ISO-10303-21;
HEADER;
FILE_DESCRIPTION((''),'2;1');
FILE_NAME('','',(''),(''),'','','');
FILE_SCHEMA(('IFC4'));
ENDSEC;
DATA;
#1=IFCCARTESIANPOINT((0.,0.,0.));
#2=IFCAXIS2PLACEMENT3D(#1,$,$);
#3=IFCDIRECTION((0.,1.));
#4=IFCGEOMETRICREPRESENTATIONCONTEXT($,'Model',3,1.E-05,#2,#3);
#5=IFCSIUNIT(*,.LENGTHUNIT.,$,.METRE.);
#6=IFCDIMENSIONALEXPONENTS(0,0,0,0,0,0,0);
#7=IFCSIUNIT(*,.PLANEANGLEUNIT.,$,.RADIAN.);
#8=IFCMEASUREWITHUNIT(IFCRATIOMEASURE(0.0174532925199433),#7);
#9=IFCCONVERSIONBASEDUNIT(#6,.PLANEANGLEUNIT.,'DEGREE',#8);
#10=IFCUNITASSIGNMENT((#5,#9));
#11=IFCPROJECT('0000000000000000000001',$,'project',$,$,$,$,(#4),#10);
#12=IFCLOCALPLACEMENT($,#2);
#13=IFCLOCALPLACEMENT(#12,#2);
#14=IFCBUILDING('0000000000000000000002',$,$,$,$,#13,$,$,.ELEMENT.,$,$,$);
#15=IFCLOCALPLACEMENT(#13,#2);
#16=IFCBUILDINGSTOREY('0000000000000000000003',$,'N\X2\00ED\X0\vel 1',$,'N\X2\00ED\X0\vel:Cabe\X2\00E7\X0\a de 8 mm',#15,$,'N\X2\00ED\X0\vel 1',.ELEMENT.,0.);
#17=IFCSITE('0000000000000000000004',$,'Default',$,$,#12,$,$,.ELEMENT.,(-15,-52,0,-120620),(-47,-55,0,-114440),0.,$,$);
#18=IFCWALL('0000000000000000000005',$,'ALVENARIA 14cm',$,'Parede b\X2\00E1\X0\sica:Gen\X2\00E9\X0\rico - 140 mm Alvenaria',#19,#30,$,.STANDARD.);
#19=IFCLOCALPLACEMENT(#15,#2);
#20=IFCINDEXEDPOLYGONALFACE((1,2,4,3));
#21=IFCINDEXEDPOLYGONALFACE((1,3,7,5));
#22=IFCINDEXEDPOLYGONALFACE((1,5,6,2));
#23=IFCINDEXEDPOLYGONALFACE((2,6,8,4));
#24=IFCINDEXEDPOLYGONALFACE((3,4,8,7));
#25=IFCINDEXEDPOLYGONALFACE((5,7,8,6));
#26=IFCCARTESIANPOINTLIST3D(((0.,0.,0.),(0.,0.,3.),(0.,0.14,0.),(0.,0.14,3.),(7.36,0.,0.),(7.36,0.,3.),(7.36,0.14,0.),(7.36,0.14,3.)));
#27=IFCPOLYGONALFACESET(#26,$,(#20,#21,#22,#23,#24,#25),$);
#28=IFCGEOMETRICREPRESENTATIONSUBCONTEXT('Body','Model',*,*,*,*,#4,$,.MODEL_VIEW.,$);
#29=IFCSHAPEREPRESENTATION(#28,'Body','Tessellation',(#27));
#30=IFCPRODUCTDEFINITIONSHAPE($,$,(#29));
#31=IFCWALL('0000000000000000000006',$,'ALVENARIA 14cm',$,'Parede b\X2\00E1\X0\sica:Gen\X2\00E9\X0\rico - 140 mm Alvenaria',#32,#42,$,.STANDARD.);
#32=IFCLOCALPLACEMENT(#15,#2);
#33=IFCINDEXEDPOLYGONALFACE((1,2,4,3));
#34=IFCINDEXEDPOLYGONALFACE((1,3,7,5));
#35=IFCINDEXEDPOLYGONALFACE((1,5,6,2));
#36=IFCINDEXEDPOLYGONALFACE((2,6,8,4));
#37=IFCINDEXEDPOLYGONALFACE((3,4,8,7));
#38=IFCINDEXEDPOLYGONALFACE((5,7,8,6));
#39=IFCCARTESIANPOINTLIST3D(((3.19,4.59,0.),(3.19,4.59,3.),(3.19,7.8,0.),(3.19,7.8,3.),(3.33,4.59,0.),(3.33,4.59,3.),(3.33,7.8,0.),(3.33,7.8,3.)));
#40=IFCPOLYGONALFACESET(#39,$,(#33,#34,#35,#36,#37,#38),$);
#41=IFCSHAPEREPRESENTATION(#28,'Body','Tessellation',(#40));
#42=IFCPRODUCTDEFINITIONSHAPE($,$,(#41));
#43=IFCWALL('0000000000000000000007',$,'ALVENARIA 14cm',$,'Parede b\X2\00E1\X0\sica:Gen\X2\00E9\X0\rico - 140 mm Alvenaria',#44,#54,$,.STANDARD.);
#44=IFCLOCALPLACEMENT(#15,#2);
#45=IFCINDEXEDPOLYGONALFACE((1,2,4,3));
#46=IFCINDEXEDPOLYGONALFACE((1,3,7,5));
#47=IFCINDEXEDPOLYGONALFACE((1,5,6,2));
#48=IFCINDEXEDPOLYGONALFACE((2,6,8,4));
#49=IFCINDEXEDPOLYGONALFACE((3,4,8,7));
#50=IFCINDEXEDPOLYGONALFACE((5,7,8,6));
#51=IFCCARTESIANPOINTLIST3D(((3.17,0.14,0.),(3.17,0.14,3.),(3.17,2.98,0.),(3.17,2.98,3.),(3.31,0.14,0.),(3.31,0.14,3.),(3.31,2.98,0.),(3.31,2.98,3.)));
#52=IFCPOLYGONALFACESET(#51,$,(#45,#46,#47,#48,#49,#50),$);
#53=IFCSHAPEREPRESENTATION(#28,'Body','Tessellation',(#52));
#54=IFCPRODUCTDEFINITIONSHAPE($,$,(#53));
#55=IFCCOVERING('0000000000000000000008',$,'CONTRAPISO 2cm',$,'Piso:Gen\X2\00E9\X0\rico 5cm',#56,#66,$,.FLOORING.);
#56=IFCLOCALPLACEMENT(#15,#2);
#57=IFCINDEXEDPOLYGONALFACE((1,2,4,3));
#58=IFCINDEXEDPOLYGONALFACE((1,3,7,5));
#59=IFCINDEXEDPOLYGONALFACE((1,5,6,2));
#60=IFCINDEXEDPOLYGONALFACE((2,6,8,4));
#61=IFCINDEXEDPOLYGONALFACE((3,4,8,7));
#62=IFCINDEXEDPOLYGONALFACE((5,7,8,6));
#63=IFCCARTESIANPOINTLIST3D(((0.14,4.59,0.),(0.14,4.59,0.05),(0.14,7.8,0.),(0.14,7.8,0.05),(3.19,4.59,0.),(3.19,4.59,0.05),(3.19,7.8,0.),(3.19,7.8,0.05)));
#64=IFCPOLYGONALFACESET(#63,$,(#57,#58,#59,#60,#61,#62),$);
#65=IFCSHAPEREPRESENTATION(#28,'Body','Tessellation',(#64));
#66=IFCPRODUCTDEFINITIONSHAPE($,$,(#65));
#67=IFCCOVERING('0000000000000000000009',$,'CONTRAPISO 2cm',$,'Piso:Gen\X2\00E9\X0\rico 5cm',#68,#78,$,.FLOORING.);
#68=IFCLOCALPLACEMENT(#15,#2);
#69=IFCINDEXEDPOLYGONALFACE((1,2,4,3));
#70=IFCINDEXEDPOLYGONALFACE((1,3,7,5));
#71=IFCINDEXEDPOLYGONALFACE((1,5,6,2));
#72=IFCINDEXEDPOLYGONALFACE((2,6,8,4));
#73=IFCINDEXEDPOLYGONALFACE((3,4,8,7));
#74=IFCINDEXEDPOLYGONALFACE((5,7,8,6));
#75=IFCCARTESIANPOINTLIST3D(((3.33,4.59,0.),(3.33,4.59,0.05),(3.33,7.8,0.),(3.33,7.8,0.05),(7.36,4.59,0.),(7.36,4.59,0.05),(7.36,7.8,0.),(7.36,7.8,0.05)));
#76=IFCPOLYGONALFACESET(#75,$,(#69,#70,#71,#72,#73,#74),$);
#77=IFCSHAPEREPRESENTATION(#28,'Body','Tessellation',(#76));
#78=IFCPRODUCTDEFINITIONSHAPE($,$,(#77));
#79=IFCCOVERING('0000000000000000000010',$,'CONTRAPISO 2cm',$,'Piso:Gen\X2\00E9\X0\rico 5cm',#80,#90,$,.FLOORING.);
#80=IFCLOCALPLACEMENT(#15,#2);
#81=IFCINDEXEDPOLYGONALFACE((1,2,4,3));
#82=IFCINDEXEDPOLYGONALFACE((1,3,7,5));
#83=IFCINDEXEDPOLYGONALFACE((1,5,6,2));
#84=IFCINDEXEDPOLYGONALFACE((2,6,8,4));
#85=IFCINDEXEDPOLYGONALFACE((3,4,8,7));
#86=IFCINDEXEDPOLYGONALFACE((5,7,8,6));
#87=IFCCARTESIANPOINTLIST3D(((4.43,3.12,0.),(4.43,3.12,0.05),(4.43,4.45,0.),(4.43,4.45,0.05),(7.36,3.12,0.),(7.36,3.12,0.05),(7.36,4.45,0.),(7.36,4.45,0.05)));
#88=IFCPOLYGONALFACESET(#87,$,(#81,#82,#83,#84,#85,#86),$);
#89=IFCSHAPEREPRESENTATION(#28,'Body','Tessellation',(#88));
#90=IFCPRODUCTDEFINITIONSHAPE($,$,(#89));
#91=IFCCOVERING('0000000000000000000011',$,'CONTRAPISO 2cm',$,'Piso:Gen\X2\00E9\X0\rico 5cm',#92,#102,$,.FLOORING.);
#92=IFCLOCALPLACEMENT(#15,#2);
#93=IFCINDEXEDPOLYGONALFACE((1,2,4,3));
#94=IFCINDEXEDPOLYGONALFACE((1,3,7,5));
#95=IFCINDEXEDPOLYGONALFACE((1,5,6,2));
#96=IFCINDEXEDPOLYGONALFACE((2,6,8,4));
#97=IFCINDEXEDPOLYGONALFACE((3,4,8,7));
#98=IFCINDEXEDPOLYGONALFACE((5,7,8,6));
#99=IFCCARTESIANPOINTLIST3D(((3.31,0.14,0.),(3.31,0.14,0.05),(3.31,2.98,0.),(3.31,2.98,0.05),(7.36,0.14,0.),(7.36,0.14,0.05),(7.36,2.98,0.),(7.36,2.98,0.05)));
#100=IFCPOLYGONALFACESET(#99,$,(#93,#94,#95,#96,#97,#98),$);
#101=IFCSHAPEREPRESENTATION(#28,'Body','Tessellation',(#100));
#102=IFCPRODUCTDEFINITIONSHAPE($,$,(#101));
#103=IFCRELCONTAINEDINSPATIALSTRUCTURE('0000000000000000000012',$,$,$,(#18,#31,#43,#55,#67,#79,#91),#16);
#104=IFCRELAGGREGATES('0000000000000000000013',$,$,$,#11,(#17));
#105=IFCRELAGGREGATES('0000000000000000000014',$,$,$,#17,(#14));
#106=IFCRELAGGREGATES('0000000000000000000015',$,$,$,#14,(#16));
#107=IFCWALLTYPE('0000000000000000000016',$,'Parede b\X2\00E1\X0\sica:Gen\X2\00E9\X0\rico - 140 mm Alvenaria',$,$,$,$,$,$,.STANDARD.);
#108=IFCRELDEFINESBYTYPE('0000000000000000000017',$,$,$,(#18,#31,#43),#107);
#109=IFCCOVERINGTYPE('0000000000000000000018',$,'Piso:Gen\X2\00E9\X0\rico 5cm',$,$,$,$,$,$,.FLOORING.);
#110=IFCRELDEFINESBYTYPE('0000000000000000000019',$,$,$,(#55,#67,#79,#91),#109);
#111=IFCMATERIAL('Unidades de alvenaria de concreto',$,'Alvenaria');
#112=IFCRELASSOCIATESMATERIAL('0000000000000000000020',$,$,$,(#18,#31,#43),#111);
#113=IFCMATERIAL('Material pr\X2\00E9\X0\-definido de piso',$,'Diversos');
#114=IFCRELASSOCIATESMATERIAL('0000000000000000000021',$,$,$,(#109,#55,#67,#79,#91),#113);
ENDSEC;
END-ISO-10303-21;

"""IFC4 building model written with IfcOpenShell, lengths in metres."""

from ifc_helpers import new_model, entity, si_unit, converted_unit, direction, frame, origin, place, context, subcontext, project, spatial, indexed_curve, outline, extrude, material, type_object, element, save


model = new_model("IFC4")

# Units and contexts
model_context = context("Model", 3, precision=1e-05, world=origin(), true_north=direction((0.0, 1.0)))
body_context = subcontext(model_context, "Body", "Model", "MODEL_VIEW")
ifc_project = project(units=[si_unit("LENGTHUNIT", "METRE"), converted_unit("PLANEANGLEUNIT", "DEGREE", entity("IfcRatioMeasure", 0.0174532925199433), si_unit("PLANEANGLEUNIT", "RADIAN"), dimensions=[0, 0, 0, 0, 0, 0, 0])], contexts=[model_context])

# Site, building, storey
site_placement = place(None, origin())
site = spatial("IfcSite", under=ifc_project, at=site_placement, Name="Default", CompositionType="ELEMENT", RefLatitude=(-15, -52, 0, -120620), RefLongitude=(-47, -55, 0, -114440), RefElevation=0.0)
building_placement = place(site_placement, origin())
building = spatial("IfcBuilding", under=site, at=building_placement, CompositionType="ELEMENT")
storey_placement = place(building_placement, origin())
storey = spatial("IfcBuildingStorey", under=building, at=storey_placement, Name="Nível 1", ObjectType="Nível:Cabeça de 8 mm", LongName="Nível 1", CompositionType="ELEMENT", Elevation=0.0)

# Walls
ifc_material_1 = material(Name="Unidades de alvenaria de concreto", Category="Alvenaria")
wall_type = type_object("IfcWallType", Name="Parede básica:Genérico - 140 mm Alvenaria", PredefinedType="STANDARD")
wall_1_placement = place(storey_placement, frame((7.36, 0.07, 0.0), z_axis=(0.0, 0.0, 1.0), x_axis=(-1.0, 0.0, 0.0)))
element("IfcWall", 1, at=wall_1_placement, inside=storey, type_object=wall_type, material=ifc_material_1, Name="ALVENARIA 14cm", ObjectType="Parede básica:Genérico - 140 mm Alvenaria", PredefinedType="STANDARD", context=body_context, shape_type="SweptSolid", body=[
    extrude(outline(indexed_curve([(7.36, 0.07), (0.0, 0.07), (0.0, -0.07), (7.36, -0.07), (7.36, 0.07)], self_intersect=False)), origin(), (0.0, 0.0, 1.0), 3.0),
])
wall_2_placement = place(storey_placement, frame((3.26, 4.59, 0.0), z_axis=(0.0, 0.0, 1.0), x_axis=(0.0, 1.0, 0.0)))
element("IfcWall", 2, at=wall_2_placement, inside=storey, type_object=wall_type, material=ifc_material_1, Name="ALVENARIA 14cm", ObjectType="Parede básica:Genérico - 140 mm Alvenaria", PredefinedType="STANDARD", context=body_context, shape_type="SweptSolid", body=[
    extrude(outline(indexed_curve([(3.21, 0.07), (0.0, 0.07), (0.0, -0.07), (3.21, -0.07), (3.21, 0.07)], self_intersect=False)), origin(), (0.0, 0.0, 1.0), 3.0),
])
wall_3_placement = place(storey_placement, frame((3.24, 2.98, 0.0), z_axis=(0.0, 0.0, 1.0), x_axis=(0.0, -1.0, 0.0)))
element("IfcWall", 3, at=wall_3_placement, inside=storey, type_object=wall_type, material=ifc_material_1, Name="ALVENARIA 14cm", ObjectType="Parede básica:Genérico - 140 mm Alvenaria", PredefinedType="STANDARD", context=body_context, shape_type="SweptSolid", body=[
    extrude(outline(indexed_curve([(2.84, 0.07), (0.0, 0.07), (0.0, -0.07), (2.84, -0.07), (2.84, 0.07)], self_intersect=False)), origin(), (0.0, 0.0, 1.0), 3.0),
])

# Coverings
ifc_material_2 = material(Name="Material pré-definido de piso", Category="Diversos")
covering_type = type_object("IfcCoveringType", Name="Piso:Genérico 5cm", PredefinedType="FLOORING", material=ifc_material_2)
covering_1_placement = place(storey_placement, origin())
element("IfcCovering", 4, at=covering_1_placement, inside=storey, type_object=covering_type, material=ifc_material_2, Name="CONTRAPISO 2cm", ObjectType="Piso:Genérico 5cm", PredefinedType="FLOORING", context=body_context, shape_type="SweptSolid", body=[
    extrude(outline(indexed_curve([(-1.605, -1.525), (1.605, -1.525), (1.605, 1.525), (-1.605, 1.525), (-1.605, -1.525)], self_intersect=False)), frame((1.665, 6.195, 0.05), z_axis=(0.0, 0.0, -1.0), x_axis=(0.0, 1.0, 0.0)), (0.0, 0.0, 1.0), 0.05),
])
covering_2_placement = place(storey_placement, origin())
element("IfcCovering", 5, at=covering_2_placement, inside=storey, type_object=covering_type, material=ifc_material_2, Name="CONTRAPISO 2cm", ObjectType="Piso:Genérico 5cm", PredefinedType="FLOORING", context=body_context, shape_type="SweptSolid", body=[
    extrude(outline(indexed_curve([(-1.605, -2.015), (1.605, -2.015), (1.605, 2.015), (-1.605, 2.015), (-1.605, -2.015)], self_intersect=False)), frame((5.345, 6.195, 0.05), z_axis=(0.0, 0.0, -1.0), x_axis=(0.0, 1.0, 0.0)), (0.0, 0.0, 1.0), 0.05),
])
covering_3_placement = place(storey_placement, origin())
element("IfcCovering", 6, at=covering_3_placement, inside=storey, type_object=covering_type, material=ifc_material_2, Name="CONTRAPISO 2cm", ObjectType="Piso:Genérico 5cm", PredefinedType="FLOORING", context=body_context, shape_type="SweptSolid", body=[
    extrude(outline(indexed_curve([(-0.665, -1.465), (0.665, -1.465), (0.665, 1.465), (-0.665, 1.465), (-0.665, -1.465)], self_intersect=False)), frame((5.895, 3.785, 0.05), z_axis=(0.0, 0.0, -1.0), x_axis=(0.0, 1.0, 0.0)), (0.0, 0.0, 1.0), 0.05),
])
covering_4_placement = place(storey_placement, origin())
element("IfcCovering", 7, at=covering_4_placement, inside=storey, type_object=covering_type, material=ifc_material_2, Name="CONTRAPISO 2cm", ObjectType="Piso:Genérico 5cm", PredefinedType="FLOORING", context=body_context, shape_type="SweptSolid", body=[
    extrude(outline(indexed_curve([(-1.42, -2.025), (1.42, -2.025), (1.42, 2.025), (-1.42, 2.025), (-1.42, -2.025)], self_intersect=False)), frame((5.335, 1.56, 0.05), z_axis=(0.0, 0.0, -1.0), x_axis=(0.0, 1.0, 0.0)), (0.0, 0.0, 1.0), 0.05),
])

save(model, "model.ifc")
